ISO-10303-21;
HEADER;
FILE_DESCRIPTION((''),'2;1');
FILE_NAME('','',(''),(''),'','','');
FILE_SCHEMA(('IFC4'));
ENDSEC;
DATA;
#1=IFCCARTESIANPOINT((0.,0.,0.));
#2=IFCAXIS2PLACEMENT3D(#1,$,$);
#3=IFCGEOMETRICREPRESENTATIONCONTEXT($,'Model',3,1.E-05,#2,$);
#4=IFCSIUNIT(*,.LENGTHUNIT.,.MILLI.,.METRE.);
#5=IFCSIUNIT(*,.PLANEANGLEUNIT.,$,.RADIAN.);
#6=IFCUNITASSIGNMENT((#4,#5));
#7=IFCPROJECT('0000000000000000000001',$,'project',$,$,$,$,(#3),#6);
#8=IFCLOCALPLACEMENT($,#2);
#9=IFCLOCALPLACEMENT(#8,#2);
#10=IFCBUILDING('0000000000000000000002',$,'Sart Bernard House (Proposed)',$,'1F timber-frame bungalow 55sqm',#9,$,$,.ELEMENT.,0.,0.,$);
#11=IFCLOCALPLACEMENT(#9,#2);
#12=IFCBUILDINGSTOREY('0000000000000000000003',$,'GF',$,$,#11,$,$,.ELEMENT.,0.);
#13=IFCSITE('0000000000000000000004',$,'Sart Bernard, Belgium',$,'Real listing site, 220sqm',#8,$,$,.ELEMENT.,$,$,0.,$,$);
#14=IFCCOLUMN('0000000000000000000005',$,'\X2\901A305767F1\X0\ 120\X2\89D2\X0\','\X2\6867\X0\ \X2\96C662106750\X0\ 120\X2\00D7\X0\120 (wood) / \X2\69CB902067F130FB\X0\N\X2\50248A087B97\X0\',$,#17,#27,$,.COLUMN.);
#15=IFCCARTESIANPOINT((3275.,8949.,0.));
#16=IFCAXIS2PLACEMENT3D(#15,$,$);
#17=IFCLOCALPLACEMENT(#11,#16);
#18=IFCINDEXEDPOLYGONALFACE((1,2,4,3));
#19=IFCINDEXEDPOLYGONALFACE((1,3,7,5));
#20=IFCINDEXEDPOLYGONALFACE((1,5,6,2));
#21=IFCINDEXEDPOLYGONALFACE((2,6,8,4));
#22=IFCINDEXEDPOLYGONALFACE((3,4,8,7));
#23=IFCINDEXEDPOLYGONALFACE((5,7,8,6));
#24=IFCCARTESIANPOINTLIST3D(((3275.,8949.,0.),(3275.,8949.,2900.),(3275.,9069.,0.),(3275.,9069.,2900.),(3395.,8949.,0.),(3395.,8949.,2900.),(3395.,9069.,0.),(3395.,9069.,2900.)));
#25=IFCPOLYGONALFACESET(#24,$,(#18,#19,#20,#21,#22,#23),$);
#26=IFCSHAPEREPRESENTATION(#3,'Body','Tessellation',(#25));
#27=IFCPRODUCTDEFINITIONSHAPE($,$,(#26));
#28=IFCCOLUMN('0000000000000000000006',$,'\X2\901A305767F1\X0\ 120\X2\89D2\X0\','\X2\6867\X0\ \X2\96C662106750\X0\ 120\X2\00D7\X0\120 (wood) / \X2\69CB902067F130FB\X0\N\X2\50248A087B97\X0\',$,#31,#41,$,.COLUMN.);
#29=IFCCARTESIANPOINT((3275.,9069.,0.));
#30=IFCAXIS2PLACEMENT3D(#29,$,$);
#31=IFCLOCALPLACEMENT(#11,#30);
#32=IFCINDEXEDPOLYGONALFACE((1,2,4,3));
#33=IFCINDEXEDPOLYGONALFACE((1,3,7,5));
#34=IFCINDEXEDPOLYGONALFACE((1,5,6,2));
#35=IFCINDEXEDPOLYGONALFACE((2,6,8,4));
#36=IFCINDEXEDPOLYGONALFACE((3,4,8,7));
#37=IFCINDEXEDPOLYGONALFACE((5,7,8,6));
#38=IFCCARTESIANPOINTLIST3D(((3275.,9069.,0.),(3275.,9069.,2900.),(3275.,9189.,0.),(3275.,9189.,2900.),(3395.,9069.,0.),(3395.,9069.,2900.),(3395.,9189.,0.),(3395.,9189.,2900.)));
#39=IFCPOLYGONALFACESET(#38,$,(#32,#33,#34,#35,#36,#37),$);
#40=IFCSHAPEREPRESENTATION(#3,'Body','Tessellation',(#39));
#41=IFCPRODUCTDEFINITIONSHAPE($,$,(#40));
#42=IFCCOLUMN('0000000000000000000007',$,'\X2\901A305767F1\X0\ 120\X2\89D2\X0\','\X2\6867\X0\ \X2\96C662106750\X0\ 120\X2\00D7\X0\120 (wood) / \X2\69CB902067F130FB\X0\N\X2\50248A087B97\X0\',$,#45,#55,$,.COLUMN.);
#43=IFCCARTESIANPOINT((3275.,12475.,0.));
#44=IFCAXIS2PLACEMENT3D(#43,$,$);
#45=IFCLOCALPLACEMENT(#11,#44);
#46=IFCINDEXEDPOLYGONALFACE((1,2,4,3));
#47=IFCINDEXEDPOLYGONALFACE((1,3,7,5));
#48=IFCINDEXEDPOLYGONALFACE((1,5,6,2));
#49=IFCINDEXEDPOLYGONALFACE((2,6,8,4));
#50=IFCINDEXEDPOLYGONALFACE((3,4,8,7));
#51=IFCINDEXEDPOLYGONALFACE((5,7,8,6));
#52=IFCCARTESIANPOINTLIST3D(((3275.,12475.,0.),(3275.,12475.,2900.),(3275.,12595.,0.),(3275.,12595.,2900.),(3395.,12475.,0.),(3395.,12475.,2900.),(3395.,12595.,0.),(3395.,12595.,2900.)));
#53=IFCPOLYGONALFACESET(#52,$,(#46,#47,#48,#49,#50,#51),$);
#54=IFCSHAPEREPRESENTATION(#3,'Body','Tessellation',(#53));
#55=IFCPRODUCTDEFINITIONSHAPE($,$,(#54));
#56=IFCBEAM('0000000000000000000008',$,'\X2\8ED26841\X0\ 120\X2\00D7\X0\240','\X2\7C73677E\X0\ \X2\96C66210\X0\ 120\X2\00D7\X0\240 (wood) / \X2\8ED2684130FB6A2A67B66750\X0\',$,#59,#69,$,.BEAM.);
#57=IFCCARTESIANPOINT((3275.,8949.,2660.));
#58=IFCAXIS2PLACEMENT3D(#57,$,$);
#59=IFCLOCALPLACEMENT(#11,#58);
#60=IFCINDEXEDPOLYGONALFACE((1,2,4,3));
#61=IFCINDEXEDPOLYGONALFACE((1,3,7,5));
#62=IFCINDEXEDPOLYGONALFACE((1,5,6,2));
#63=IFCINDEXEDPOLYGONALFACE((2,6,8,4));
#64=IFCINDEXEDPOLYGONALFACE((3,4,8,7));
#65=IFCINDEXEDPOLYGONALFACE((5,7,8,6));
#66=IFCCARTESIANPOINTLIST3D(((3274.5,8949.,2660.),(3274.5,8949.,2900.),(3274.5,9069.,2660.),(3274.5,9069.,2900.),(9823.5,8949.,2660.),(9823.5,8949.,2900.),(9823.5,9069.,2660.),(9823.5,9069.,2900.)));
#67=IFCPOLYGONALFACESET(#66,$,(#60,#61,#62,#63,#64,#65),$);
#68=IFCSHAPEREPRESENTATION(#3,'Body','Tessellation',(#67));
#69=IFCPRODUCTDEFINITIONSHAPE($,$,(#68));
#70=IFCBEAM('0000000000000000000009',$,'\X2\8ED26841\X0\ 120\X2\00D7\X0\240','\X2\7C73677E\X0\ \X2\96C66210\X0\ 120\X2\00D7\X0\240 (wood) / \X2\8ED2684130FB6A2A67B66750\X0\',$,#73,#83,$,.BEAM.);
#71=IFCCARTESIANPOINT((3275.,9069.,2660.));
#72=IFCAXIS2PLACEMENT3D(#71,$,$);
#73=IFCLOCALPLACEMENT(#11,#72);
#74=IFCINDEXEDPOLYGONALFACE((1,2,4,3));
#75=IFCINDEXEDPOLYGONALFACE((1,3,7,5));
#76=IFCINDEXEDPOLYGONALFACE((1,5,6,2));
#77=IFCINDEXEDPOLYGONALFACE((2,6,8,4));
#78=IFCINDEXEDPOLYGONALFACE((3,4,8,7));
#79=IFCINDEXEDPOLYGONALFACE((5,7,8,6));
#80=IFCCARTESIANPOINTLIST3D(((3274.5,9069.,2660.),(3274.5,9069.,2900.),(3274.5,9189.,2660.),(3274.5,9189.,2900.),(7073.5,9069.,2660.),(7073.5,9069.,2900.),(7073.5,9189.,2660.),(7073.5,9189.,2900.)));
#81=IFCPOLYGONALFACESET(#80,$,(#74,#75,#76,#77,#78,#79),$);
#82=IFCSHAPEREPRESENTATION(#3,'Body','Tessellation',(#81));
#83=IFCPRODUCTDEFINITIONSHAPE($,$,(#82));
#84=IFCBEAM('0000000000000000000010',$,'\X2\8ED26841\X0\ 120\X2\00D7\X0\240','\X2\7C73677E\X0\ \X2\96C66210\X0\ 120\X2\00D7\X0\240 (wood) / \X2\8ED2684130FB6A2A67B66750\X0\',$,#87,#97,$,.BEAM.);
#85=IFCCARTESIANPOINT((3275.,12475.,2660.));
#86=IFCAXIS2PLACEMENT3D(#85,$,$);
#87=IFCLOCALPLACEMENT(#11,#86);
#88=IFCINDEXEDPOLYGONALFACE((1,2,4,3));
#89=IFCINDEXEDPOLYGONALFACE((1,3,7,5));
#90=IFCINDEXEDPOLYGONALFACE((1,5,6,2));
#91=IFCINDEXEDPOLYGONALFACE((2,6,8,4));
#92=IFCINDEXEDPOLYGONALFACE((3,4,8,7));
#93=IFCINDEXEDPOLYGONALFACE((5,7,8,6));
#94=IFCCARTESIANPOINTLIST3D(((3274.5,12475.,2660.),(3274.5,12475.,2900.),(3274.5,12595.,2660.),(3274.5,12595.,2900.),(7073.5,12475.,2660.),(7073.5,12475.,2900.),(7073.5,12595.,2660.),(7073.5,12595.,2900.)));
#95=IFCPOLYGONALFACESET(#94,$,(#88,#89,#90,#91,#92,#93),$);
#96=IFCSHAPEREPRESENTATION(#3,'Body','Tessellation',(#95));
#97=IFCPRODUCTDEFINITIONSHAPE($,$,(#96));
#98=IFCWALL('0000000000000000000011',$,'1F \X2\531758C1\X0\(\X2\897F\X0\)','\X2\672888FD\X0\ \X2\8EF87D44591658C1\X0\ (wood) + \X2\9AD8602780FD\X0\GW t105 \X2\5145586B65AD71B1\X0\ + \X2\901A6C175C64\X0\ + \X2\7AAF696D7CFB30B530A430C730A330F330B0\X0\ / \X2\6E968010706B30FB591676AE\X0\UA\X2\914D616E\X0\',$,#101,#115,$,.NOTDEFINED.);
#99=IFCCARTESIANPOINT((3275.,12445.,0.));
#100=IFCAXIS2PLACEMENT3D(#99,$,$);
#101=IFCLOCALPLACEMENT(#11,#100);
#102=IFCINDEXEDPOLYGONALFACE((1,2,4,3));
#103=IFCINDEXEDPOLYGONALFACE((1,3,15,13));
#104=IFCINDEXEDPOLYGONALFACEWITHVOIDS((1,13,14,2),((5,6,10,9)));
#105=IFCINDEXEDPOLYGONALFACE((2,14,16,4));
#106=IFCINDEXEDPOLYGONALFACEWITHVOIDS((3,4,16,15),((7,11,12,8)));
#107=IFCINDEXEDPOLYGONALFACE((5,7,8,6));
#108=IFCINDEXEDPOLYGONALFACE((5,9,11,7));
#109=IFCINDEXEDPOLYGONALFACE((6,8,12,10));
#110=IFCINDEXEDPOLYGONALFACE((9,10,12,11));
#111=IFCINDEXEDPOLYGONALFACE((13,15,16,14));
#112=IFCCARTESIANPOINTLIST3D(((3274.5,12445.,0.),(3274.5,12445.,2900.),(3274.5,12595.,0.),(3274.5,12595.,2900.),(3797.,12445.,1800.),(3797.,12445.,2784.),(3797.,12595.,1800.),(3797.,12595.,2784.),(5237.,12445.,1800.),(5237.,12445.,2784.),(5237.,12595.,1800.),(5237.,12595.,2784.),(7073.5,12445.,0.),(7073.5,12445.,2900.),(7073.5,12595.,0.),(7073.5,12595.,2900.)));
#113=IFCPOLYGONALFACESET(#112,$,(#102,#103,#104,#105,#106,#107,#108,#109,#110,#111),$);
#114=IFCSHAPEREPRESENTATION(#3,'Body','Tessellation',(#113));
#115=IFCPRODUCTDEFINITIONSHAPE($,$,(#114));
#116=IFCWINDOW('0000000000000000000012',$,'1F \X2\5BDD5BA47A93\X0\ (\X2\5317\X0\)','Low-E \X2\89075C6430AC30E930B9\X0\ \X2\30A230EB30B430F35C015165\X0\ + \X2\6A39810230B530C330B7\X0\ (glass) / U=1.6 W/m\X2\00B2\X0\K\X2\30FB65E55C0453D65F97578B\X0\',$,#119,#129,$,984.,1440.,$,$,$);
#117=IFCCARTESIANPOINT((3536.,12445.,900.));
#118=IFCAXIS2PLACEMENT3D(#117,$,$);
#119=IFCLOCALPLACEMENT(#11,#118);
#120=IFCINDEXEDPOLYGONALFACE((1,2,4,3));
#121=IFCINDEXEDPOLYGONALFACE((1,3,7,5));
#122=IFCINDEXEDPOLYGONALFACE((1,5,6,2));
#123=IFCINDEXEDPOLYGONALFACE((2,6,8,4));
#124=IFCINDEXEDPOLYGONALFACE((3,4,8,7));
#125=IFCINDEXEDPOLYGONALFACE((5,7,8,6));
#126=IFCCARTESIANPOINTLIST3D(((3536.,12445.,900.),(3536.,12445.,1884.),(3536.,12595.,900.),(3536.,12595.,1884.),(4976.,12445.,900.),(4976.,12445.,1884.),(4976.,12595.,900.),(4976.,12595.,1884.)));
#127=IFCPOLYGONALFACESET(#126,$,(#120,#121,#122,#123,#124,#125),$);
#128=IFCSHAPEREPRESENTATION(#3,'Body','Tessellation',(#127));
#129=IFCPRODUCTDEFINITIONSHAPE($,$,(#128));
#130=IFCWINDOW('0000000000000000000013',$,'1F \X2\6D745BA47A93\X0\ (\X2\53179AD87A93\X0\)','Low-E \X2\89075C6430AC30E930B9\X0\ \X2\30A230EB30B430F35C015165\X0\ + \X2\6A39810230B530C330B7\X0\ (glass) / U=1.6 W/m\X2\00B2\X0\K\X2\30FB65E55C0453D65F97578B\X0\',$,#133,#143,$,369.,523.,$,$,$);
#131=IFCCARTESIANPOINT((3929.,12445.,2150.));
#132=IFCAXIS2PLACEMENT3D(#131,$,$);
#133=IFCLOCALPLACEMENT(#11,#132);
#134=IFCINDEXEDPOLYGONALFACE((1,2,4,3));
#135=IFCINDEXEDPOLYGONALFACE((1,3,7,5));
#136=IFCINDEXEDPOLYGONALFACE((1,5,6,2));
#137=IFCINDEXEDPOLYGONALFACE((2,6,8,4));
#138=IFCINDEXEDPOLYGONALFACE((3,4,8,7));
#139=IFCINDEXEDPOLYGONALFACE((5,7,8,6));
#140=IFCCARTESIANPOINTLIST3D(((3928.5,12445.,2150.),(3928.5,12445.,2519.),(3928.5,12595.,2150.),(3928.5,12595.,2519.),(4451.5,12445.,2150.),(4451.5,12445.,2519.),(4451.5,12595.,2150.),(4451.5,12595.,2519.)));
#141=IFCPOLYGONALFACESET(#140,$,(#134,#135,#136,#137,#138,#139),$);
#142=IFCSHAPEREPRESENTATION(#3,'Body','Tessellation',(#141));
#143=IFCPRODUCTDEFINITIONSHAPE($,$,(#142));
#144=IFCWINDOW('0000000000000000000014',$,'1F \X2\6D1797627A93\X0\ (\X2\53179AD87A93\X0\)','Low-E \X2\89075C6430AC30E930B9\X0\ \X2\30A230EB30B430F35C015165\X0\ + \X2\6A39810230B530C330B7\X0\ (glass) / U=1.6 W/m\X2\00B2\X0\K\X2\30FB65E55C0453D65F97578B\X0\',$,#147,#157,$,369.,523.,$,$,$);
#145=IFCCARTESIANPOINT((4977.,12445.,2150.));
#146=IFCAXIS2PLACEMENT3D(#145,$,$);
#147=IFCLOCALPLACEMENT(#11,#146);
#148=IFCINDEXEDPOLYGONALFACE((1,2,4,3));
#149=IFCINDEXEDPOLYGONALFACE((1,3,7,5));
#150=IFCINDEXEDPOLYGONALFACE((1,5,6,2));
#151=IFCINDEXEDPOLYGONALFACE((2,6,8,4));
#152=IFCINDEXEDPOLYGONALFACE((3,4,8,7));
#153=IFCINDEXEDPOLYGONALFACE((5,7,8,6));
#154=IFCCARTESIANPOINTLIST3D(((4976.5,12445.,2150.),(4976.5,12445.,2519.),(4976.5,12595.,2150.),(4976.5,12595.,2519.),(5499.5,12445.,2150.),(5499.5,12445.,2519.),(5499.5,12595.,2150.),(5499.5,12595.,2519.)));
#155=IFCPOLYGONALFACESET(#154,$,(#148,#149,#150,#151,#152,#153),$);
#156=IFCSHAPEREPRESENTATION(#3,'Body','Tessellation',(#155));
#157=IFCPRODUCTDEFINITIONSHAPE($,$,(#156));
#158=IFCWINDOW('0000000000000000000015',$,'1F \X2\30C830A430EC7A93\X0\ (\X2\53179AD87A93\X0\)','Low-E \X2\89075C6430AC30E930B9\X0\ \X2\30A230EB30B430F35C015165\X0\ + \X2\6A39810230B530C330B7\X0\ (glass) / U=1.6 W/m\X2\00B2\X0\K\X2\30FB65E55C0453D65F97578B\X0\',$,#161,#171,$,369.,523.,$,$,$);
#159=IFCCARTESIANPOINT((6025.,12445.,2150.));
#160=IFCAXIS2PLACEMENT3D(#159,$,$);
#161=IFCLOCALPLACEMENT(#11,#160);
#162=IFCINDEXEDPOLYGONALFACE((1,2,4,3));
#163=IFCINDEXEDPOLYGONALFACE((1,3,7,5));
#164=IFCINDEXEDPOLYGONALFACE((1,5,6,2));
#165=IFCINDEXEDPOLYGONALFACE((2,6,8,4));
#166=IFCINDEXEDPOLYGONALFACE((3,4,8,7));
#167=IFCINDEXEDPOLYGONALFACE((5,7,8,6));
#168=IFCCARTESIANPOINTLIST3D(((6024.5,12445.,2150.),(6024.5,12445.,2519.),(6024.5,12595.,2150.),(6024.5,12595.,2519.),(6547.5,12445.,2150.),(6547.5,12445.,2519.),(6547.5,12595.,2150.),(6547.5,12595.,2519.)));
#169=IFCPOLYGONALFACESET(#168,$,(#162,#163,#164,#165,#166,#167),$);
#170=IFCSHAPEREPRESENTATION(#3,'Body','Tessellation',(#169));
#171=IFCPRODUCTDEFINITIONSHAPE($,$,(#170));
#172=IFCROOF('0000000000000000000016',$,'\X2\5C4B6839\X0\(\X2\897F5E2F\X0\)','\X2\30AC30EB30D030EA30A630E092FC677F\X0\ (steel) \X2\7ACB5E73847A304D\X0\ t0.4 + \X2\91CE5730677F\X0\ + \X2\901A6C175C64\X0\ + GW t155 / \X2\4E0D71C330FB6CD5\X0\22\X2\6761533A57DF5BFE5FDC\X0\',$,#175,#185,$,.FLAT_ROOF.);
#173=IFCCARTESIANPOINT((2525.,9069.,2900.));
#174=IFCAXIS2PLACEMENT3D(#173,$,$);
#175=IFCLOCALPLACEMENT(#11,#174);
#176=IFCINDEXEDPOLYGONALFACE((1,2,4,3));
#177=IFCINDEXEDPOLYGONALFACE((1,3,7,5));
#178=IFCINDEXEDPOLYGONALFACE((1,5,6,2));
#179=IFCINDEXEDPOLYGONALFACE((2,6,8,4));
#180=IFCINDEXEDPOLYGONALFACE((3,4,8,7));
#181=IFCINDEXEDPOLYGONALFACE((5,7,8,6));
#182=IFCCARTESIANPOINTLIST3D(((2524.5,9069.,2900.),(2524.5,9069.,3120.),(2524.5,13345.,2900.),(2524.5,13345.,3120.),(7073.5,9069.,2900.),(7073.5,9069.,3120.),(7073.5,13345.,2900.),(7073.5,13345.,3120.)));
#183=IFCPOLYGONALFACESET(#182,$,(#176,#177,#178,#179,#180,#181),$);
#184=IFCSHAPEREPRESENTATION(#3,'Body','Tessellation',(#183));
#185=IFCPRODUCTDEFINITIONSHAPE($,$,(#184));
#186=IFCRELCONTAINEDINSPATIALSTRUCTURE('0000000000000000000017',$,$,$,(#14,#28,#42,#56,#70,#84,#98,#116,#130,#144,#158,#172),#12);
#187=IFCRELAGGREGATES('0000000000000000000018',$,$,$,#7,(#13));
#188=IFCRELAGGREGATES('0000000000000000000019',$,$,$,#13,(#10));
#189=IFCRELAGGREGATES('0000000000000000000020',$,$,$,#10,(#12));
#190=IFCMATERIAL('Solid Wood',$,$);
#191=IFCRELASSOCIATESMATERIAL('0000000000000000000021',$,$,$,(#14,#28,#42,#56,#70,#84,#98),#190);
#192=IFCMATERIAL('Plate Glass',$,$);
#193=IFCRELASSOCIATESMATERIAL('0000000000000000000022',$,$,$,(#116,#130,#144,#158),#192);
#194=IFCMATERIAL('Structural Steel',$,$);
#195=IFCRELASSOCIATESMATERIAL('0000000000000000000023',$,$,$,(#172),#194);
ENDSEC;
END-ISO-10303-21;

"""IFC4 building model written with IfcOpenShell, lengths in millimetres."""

from ifc_helpers import new_model, si_unit, frame, frame_2d, origin, place, context, project, spatial, rectangle, extrude, material, element, fill, save


model = new_model("IFC4")

# Units and contexts
model_context = context("Model", 3, precision=1e-05, world=origin())
ifc_project = project(units=[si_unit("LENGTHUNIT", "METRE", prefix="MILLI"), si_unit("PLANEANGLEUNIT", "RADIAN")], contexts=[model_context])

# Site, building, storey
site_placement = place(None, origin())
site = spatial("IfcSite", under=ifc_project, at=site_placement, Name="Sart Bernard, Belgium", ObjectType="Real listing site, 220sqm", CompositionType="ELEMENT", RefElevation=0.0)
building_placement = place(site_placement, origin())
building = spatial("IfcBuilding", under=site, at=building_placement, Name="Sart Bernard House (Proposed)", ObjectType="1F timber-frame bungalow 55sqm", CompositionType="ELEMENT", ElevationOfRefHeight=0.0, ElevationOfTerrain=0.0)
storey_placement = place(building_placement, origin())
storey = spatial("IfcBuildingStorey", under=building, at=storey_placement, Name="GF", CompositionType="ELEMENT", Elevation=0.0)

# Columns
ifc_material_1 = material(Name="Solid Wood")
column_1_placement = place(storey_placement, frame((3275.0, 8949.0, 0.0)))
element("IfcColumn", 1, at=column_1_placement, inside=storey, material=ifc_material_1, Name="通し柱 120角", Description="桧 集成材 120×120 (wood) / 構造柱・N値計算", PredefinedType="COLUMN", context=model_context, shape_type="SweptSolid", body=[
    extrude(rectangle(XDim=120.0, YDim=120.0, at=frame_2d((60.0, 60.0))), frame((3275.0, 8949.0, 0.0)), (0.0, 0.0, 1.0), 2900.0),
])
column_2_placement = place(storey_placement, frame((3275.0, 9069.0, 0.0)))
element("IfcColumn", 2, at=column_2_placement, inside=storey, material=ifc_material_1, Name="通し柱 120角", Description="桧 集成材 120×120 (wood) / 構造柱・N値計算", PredefinedType="COLUMN", context=model_context, shape_type="SweptSolid", body=[
    extrude(rectangle(XDim=120.0, YDim=120.0, at=frame_2d((60.0, 60.0))), frame((3275.0, 9069.0, 0.0)), (0.0, 0.0, 1.0), 2900.0),
])
column_3_placement = place(storey_placement, frame((3275.0, 12475.0, 0.0)))
element("IfcColumn", 3, at=column_3_placement, inside=storey, material=ifc_material_1, Name="通し柱 120角", Description="桧 集成材 120×120 (wood) / 構造柱・N値計算", PredefinedType="COLUMN", context=model_context, shape_type="SweptSolid", body=[
    extrude(rectangle(XDim=120.0, YDim=120.0, at=frame_2d((60.0, 60.0))), frame((3275.0, 12475.0, 0.0)), (0.0, 0.0, 1.0), 2900.0),
])

# Beams
beam_1_placement = place(storey_placement, frame((3275.0, 8949.0, 2660.0)))
element("IfcBeam", 4, at=beam_1_placement, inside=storey, material=ifc_material_1, Name="軒桁 120×240", Description="米松 集成 120×240 (wood) / 軒桁・横架材", PredefinedType="BEAM", context=model_context, shape_type="SweptSolid", body=[
    extrude(rectangle(XDim=6549.0, YDim=120.0, at=frame_2d((3274.0, 60.0))), frame((3275.0, 8949.0, 2660.0)), (0.0, 0.0, 1.0), 240.0),
])
beam_2_placement = place(storey_placement, frame((3275.0, 9069.0, 2660.0)))
element("IfcBeam", 5, at=beam_2_placement, inside=storey, material=ifc_material_1, Name="軒桁 120×240", Description="米松 集成 120×240 (wood) / 軒桁・横架材", PredefinedType="BEAM", context=model_context, shape_type="SweptSolid", body=[
    extrude(rectangle(XDim=3799.0, YDim=120.0, at=frame_2d((1899.0, 60.0))), frame((3275.0, 9069.0, 2660.0)), (0.0, 0.0, 1.0), 240.0),
])
beam_3_placement = place(storey_placement, frame((3275.0, 12475.0, 2660.0)))
element("IfcBeam", 6, at=beam_3_placement, inside=storey, material=ifc_material_1, Name="軒桁 120×240", Description="米松 集成 120×240 (wood) / 軒桁・横架材", PredefinedType="BEAM", context=model_context, shape_type="SweptSolid", body=[
    extrude(rectangle(XDim=3799.0, YDim=120.0, at=frame_2d((1899.0, 60.0))), frame((3275.0, 12475.0, 2660.0)), (0.0, 0.0, 1.0), 240.0),
])

# Wall, openings, windows
wall_1_placement = place(storey_placement, frame((3275.0, 12445.0, 0.0)))
wall_1 = element("IfcWall", 7, at=wall_1_placement, inside=storey, material=ifc_material_1, Name="1F 北壁(西)", Description="木製 軸組外壁 (wood) + 高性能GW t105 充填断熱 + 通気層 + 窯業系サイディング / 準耐火・外皮UA配慮", PredefinedType="NOTDEFINED", context=model_context, shape_type="SweptSolid", body=[
    extrude(rectangle(XDim=3799.0, YDim=150.0, at=frame_2d((1899.0, 75.0))), frame((3275.0, 12445.0, 0.0)), (0.0, 0.0, 1.0), 2900.0),
])
opening_1_placement = place(storey_placement, frame((3536.0, 12445.0, 900.0)))
opening_1 = element("IfcOpeningElement", 8, at=opening_1_placement, cuts=wall_1, PredefinedType="NOTDEFINED", context=model_context, shape_type="SweptSolid", body=[
    extrude(rectangle(XDim=1440.0, YDim=150.0, at=frame_2d((720.0, 75.0))), frame((3536.0, 12445.0, 900.0)), (0.0, 0.0, 1.0), 984.0),
])
opening_2_placement = place(storey_placement, frame((3929.0, 12445.0, 2150.0)))
opening_2 = element("IfcOpeningElement", 9, at=opening_2_placement, cuts=wall_1, PredefinedType="NOTDEFINED", context=model_context, shape_type="SweptSolid", body=[
    extrude(rectangle(XDim=523.0, YDim=150.0, at=frame_2d((261.0, 75.0))), frame((3929.0, 12445.0, 2150.0)), (0.0, 0.0, 1.0), 369.0),
])
opening_3_placement = place(storey_placement, frame((4977.0, 12445.0, 2150.0)))
opening_3 = element("IfcOpeningElement", 10, at=opening_3_placement, cuts=wall_1, PredefinedType="NOTDEFINED", context=model_context, shape_type="SweptSolid", body=[
    extrude(rectangle(XDim=523.0, YDim=150.0, at=frame_2d((261.0, 75.0))), frame((4977.0, 12445.0, 2150.0)), (0.0, 0.0, 1.0), 369.0),
])
opening_4_placement = place(storey_placement, frame((6025.0, 12445.0, 2150.0)))
opening_4 = element("IfcOpeningElement", 11, at=opening_4_placement, cuts=wall_1, PredefinedType="NOTDEFINED", context=model_context, shape_type="SweptSolid", body=[
    extrude(rectangle(XDim=523.0, YDim=150.0, at=frame_2d((261.0, 75.0))), frame((6025.0, 12445.0, 2150.0)), (0.0, 0.0, 1.0), 369.0),
])
ifc_material_2 = material(Name="Plate Glass")
window_1_placement = place(storey_placement, frame((3536.0, 12445.0, 900.0)))
window_1 = element("IfcWindow", 12, at=window_1_placement, inside=storey, material=ifc_material_2, Name="1F 寝室窓 (北)", Description="Low-E 複層ガラス アルゴン封入 + 樹脂サッシ (glass) / U=1.6 W/m²K・日射取得型", OverallHeight=984.0, OverallWidth=1440.0, context=model_context, shape_type="SweptSolid", body=[
    extrude(rectangle(XDim=1440.0, YDim=150.0, at=frame_2d((720.0, 75.0))), frame((3536.0, 12445.0, 900.0)), (0.0, 0.0, 1.0), 984.0),
])
fill(opening_1, window_1)
window_2_placement = place(storey_placement, frame((3929.0, 12445.0, 2150.0)))
window_2 = element("IfcWindow", 13, at=window_2_placement, inside=storey, material=ifc_material_2, Name="1F 浴室窓 (北高窓)", Description="Low-E 複層ガラス アルゴン封入 + 樹脂サッシ (glass) / U=1.6 W/m²K・日射取得型", OverallHeight=369.0, OverallWidth=523.0, context=model_context, shape_type="SweptSolid", body=[
    extrude(rectangle(XDim=523.0, YDim=150.0, at=frame_2d((261.0, 75.0))), frame((3929.0, 12445.0, 2150.0)), (0.0, 0.0, 1.0), 369.0),
])
fill(opening_2, window_2)
window_3_placement = place(storey_placement, frame((4977.0, 12445.0, 2150.0)))
window_3 = element("IfcWindow", 14, at=window_3_placement, inside=storey, material=ifc_material_2, Name="1F 洗面窓 (北高窓)", Description="Low-E 複層ガラス アルゴン封入 + 樹脂サッシ (glass) / U=1.6 W/m²K・日射取得型", OverallHeight=369.0, OverallWidth=523.0, context=model_context, shape_type="SweptSolid", body=[
    extrude(rectangle(XDim=523.0, YDim=150.0, at=frame_2d((261.0, 75.0))), frame((4977.0, 12445.0, 2150.0)), (0.0, 0.0, 1.0), 369.0),
])
fill(opening_3, window_3)
window_4_placement = place(storey_placement, frame((6025.0, 12445.0, 2150.0)))
window_4 = element("IfcWindow", 15, at=window_4_placement, inside=storey, material=ifc_material_2, Name="1F トイレ窓 (北高窓)", Description="Low-E 複層ガラス アルゴン封入 + 樹脂サッシ (glass) / U=1.6 W/m²K・日射取得型", OverallHeight=369.0, OverallWidth=523.0, context=model_context, shape_type="SweptSolid", body=[
    extrude(rectangle(XDim=523.0, YDim=150.0, at=frame_2d((261.0, 75.0))), frame((6025.0, 12445.0, 2150.0)), (0.0, 0.0, 1.0), 369.0),
])
fill(opening_4, window_4)

# Roof
ifc_material_3 = material(Name="Structural Steel")
roof_placement = place(storey_placement, frame((2525.0, 9069.0, 2900.0)))
element("IfcRoof", 16, at=roof_placement, inside=storey, material=ifc_material_3, Name="屋根(西帯)", Description="ガルバリウム鋼板 (steel) 立平葺き t0.4 + 野地板 + 通気層 + GW t155 / 不燃・法22条区域対応", PredefinedType="FLAT_ROOF", context=model_context, shape_type="SweptSolid", body=[
    extrude(rectangle(XDim=4549.0, YDim=4276.0, at=frame_2d((2274.0, 2138.0))), frame((2525.0, 9069.0, 2900.0)), (0.0, 0.0, 1.0), 220.0),
])

save(model, "model.ifc")
